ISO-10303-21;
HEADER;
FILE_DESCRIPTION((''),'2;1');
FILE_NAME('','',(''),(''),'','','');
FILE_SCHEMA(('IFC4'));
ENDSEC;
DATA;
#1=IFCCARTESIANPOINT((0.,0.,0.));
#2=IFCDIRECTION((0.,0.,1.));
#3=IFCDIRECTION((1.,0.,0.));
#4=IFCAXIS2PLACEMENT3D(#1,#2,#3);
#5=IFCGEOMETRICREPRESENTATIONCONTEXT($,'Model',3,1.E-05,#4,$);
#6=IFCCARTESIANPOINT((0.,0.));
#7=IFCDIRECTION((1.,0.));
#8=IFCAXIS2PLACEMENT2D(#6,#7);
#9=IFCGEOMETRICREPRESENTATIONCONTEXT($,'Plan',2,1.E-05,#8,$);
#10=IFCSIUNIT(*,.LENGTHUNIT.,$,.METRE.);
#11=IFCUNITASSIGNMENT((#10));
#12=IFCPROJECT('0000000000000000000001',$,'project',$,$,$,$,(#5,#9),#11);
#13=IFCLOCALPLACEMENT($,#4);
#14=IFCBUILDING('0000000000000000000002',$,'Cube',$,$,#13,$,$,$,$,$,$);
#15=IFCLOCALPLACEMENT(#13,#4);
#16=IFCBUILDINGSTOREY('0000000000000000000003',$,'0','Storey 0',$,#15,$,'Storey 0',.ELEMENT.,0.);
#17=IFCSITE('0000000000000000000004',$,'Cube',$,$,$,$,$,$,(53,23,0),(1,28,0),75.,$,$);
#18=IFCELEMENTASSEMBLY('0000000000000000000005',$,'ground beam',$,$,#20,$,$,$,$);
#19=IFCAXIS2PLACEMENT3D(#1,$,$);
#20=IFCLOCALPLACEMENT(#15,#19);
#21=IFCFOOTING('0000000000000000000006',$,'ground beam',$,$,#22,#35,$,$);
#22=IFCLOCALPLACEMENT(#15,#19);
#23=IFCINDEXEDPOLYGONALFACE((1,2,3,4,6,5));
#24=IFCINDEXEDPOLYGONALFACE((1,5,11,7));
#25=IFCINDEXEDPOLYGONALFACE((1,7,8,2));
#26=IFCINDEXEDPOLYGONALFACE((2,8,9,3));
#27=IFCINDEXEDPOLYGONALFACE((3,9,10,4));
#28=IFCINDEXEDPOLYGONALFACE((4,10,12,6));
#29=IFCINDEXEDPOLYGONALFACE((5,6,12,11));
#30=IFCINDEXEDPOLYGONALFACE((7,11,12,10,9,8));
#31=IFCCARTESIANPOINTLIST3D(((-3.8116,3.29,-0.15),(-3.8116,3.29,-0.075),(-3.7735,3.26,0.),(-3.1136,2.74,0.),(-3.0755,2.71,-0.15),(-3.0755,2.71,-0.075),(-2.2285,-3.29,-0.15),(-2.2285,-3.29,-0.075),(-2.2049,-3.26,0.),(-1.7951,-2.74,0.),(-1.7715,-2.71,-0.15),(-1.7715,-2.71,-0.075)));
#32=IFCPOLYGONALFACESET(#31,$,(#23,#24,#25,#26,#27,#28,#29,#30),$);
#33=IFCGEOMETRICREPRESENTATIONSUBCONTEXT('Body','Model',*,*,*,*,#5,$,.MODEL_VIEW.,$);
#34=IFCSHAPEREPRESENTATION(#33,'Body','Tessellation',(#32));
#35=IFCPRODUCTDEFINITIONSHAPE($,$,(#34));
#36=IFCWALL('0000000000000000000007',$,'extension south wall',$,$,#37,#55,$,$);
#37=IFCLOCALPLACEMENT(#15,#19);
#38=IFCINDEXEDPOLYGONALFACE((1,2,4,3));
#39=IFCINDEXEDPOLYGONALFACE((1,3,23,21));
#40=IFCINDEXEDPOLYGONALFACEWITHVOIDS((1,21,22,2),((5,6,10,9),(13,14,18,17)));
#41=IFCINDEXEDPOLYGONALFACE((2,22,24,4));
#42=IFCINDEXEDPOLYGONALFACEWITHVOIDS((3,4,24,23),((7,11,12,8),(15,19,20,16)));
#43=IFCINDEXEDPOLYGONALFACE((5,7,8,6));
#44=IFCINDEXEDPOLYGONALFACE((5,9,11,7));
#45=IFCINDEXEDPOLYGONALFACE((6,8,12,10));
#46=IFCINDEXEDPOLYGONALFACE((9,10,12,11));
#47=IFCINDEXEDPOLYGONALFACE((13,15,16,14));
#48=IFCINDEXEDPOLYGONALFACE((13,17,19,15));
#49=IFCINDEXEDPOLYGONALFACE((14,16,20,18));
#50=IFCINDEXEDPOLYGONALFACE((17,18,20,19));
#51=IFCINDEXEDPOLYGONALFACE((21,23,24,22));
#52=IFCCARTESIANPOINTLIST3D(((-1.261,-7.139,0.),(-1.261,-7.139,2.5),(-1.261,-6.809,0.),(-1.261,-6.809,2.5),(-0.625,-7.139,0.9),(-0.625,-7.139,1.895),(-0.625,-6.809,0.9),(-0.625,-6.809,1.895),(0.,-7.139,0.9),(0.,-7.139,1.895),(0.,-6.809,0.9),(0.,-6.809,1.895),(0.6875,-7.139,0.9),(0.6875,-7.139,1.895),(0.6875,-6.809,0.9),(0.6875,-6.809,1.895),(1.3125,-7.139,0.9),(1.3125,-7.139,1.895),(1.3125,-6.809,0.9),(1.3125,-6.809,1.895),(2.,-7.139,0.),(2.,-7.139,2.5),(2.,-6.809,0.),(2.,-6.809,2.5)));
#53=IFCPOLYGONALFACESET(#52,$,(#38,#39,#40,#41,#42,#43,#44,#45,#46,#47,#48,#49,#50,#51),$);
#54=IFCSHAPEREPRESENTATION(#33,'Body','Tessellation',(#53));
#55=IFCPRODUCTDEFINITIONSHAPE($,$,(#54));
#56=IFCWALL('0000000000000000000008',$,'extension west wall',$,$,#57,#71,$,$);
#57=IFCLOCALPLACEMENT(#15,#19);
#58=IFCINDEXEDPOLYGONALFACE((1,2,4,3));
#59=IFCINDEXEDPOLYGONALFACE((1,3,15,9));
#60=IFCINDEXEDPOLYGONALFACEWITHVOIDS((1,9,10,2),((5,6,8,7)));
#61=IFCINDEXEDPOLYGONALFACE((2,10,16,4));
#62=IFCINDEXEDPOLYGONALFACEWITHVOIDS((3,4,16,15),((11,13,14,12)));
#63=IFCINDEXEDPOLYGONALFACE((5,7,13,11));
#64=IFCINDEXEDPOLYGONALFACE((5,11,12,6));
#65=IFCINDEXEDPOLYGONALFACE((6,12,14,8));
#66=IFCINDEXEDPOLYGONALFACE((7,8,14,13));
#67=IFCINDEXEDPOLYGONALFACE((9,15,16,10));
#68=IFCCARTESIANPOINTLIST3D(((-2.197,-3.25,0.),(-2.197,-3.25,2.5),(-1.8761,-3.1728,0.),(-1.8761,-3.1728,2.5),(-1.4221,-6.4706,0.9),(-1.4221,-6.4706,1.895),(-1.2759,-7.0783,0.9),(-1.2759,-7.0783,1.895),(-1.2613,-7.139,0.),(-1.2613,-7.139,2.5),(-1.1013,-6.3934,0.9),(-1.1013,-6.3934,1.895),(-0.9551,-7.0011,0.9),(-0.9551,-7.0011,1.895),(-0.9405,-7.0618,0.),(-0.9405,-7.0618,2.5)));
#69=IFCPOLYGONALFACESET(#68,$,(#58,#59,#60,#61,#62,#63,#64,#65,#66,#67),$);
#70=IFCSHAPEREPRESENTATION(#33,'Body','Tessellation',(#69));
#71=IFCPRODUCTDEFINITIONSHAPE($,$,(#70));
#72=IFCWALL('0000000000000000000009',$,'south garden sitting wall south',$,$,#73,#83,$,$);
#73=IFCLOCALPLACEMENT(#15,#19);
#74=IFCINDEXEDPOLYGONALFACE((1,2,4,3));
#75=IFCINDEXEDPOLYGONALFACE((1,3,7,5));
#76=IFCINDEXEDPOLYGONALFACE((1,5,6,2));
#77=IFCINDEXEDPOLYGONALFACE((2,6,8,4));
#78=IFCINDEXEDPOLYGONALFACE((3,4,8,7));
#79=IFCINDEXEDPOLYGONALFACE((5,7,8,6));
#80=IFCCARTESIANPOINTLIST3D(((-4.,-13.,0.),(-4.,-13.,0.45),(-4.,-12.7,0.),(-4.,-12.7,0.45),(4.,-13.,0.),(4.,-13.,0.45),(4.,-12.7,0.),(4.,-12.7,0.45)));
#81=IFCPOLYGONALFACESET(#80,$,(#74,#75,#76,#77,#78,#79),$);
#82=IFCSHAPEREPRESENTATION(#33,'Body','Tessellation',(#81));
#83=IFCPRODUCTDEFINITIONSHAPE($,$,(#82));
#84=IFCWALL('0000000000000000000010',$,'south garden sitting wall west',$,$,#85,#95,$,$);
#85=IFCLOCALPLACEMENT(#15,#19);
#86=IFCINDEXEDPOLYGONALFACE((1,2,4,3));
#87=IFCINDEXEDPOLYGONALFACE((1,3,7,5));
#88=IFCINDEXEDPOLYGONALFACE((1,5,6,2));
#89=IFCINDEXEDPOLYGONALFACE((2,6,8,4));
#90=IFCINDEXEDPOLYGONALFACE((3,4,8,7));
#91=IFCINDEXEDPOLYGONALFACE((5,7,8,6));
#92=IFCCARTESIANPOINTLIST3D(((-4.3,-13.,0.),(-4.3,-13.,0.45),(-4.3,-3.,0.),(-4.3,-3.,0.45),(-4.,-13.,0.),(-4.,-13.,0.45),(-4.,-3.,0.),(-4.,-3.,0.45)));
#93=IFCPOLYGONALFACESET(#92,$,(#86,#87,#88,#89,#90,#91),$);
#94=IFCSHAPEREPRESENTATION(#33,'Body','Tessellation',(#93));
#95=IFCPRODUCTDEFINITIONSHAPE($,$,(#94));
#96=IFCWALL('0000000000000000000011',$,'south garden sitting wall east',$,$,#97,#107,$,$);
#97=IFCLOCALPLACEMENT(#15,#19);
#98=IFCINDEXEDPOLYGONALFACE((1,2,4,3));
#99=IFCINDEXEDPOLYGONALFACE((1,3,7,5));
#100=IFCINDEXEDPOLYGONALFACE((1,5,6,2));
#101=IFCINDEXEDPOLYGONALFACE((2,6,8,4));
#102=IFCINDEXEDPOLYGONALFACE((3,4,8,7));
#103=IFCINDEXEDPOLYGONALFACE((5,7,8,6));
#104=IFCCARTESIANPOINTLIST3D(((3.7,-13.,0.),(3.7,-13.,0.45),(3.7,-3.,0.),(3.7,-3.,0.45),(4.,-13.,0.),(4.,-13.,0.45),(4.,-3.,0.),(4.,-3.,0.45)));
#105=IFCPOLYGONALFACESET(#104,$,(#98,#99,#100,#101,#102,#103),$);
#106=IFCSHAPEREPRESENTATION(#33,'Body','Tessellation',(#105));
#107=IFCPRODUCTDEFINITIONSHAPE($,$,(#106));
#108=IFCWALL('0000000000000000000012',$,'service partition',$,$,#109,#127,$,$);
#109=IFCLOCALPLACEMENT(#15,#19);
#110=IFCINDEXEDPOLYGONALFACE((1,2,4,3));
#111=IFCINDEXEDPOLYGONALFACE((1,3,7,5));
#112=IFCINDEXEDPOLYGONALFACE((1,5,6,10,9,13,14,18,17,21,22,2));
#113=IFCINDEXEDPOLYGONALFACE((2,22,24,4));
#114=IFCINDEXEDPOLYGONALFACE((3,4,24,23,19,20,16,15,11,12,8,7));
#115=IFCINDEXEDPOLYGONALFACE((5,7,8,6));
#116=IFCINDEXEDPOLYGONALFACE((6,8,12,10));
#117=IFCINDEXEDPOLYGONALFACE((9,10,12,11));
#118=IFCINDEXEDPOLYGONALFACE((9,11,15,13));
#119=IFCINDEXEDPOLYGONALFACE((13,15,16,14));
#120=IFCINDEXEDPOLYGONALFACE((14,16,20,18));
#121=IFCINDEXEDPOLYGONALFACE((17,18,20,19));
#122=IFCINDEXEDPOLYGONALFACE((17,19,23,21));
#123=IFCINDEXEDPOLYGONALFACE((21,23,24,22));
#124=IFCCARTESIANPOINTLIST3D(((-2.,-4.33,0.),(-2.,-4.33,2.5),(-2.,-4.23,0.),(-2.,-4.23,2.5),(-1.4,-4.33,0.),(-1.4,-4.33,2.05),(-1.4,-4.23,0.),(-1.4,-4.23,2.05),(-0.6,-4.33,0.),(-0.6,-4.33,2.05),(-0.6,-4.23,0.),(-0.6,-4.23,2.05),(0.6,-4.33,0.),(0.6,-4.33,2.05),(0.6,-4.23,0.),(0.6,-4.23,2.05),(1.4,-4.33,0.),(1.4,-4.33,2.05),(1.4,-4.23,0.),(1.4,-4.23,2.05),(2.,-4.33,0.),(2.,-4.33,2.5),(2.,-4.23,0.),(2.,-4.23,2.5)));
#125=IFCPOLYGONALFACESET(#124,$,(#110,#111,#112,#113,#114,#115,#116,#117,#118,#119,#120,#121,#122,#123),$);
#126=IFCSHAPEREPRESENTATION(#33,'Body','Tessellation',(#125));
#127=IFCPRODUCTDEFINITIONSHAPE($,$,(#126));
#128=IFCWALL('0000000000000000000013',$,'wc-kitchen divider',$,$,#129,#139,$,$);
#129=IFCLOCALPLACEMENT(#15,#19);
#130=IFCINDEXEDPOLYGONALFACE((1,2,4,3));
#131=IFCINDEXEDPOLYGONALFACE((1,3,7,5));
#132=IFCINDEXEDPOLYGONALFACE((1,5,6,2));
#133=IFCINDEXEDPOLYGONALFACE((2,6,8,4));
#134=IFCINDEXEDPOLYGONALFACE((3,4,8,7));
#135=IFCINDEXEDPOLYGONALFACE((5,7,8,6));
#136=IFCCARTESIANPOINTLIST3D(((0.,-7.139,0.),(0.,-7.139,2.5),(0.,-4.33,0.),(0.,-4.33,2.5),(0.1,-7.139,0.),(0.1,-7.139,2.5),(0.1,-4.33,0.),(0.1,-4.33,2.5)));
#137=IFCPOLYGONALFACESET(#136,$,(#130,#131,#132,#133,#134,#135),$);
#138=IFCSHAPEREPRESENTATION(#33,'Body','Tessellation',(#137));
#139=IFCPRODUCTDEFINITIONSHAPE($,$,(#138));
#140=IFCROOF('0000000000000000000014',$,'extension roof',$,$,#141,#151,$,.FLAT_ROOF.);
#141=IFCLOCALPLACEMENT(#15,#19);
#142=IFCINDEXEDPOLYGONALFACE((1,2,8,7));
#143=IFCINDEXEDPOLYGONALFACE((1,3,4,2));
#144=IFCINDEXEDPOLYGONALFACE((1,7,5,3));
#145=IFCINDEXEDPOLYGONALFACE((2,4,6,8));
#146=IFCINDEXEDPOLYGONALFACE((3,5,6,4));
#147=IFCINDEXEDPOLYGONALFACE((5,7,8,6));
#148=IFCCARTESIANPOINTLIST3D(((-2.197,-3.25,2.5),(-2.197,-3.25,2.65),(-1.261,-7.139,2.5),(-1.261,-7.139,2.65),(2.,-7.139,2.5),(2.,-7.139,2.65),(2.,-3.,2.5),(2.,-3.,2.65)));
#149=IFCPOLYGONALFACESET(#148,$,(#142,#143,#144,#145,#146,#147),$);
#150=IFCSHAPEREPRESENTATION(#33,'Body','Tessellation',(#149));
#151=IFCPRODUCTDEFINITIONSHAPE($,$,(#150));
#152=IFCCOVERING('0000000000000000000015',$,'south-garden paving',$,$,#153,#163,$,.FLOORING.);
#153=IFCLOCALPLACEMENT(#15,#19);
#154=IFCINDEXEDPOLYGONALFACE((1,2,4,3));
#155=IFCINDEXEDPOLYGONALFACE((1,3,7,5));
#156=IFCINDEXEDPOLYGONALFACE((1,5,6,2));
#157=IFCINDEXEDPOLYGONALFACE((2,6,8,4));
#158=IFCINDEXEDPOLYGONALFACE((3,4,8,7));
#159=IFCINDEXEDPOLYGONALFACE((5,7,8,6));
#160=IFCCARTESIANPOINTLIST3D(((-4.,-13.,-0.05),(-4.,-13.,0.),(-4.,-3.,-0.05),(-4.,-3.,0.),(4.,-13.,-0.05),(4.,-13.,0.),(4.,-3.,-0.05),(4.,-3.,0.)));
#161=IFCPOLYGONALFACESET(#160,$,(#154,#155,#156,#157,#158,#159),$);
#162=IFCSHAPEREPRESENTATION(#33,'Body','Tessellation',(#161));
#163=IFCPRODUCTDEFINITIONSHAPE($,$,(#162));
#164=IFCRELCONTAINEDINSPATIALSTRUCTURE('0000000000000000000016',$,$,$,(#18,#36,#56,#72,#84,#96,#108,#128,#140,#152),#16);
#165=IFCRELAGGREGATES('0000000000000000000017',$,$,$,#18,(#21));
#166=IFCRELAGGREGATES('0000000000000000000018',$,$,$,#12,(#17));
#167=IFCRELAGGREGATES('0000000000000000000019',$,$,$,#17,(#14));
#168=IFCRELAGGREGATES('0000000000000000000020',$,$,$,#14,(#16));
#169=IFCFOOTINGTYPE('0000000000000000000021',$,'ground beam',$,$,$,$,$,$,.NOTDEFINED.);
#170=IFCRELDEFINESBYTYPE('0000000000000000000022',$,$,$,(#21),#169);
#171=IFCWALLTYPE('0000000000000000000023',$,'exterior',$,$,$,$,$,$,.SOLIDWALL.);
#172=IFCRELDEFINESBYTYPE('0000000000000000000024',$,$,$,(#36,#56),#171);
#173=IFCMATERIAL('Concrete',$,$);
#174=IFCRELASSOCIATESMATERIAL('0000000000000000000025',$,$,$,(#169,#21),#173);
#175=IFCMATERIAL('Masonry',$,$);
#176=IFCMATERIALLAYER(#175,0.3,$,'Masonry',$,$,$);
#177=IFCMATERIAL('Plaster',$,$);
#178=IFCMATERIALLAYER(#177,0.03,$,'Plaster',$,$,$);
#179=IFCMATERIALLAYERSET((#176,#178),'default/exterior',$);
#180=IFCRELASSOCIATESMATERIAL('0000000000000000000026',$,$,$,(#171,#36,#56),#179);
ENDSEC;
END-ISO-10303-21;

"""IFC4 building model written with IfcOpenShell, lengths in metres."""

from ifc_helpers import new_model, si_unit, frame, origin_with_axes, origin_2d_with_axis, place, context, subcontext, project, spatial, polyline, indexed_curve, outline, extrude, clip, halfspace, material, layer, layer_set, layer_usage, material_profile, profile_set, profile_usage, type_object, element, aggregate, save


model = new_model("IFC4")

# Units and contexts
model_context = context("Model", 3, precision=1e-05, world=origin_with_axes())
plan_context = context("Plan", 2, precision=1e-05, world=origin_2d_with_axis())
body_context_1 = subcontext(model_context, "Body", "Model", "MODEL_VIEW")
ifc_project = project(units=[si_unit("LENGTHUNIT", "METRE")], contexts=[model_context, plan_context])

# Site, building, storey
site = spatial("IfcSite", under=ifc_project, Name="Cube", RefLatitude=(53, 23, 0), RefLongitude=(1, 28, 0), RefElevation=75.0)
building_placement = place(None, origin_with_axes())
building = spatial("IfcBuilding", under=site, at=building_placement, Name="Cube")
storey_placement = place(building_placement, origin_with_axes())
storey = spatial("IfcBuildingStorey", under=building, at=storey_placement, Name="0", Description="Storey 0", LongName="Storey 0", CompositionType="ELEMENT", Elevation=0.0)

# Element assembly, footing
assembly_placement = place(storey_placement, origin_with_axes())
assembly = element("IfcElementAssembly", 1, at=assembly_placement, inside=storey, Name="ground beam")
ifc_material_1 = material(Name="Concrete")
ifc_material_profile = material_profile(ifc_material_1, outline(polyline([(-0.26, 0.0), (-0.29, -0.075), (-0.29, -0.15), (0.29, -0.15), (0.29, -0.075), (0.26, 0.0), (-0.26, 0.0)])))
ifc_profile_set = profile_set([ifc_material_profile])
ifc_profile_usage = profile_usage(ifc_profile_set)
footing_type = type_object("IfcFootingType", Name="ground beam", PredefinedType="NOTDEFINED", material=ifc_profile_set)
footing_placement = place(assembly_placement, frame((-1.7661, -3.9723, 0.0), z_axis=(-0.233915, 0.972257, 0.0), x_axis=(-0.972257, -0.233915, 0.0)))
footing = element("IfcFooting", 2, at=footing_placement, type_object=footing_type, material=ifc_profile_usage, Name="ground beam", context=body_context_1, shape_type="Clipping", body=[
    clip(clip(extrude(outline(polyline([(-0.26, 0.0), (-0.29, -0.075), (-0.29, -0.15), (0.29, -0.15), (0.29, -0.075), (0.26, 0.0), (-0.26, 0.0)])), origin_with_axes(), (0.0, 0.0, 1.0), 8.1712), halfspace(frame((0.0, 0.0, 1.0), z_axis=(-0.618904, 0.0, -0.785467), x_axis=(0.0, 1.0, 0.0)), False)), halfspace(frame((0.0, 0.0, 7.1712), z_axis=(-0.785467, 0.0, 0.618904), x_axis=(0.0, 1.0, 0.0)), False)),
])
aggregate(assembly, [footing])

# Wall, openings
ifc_material_2 = material(Name="Masonry")
ifc_layer_1 = layer(ifc_material_2, 0.3, Name="Masonry")
ifc_material_3 = material(Name="Plaster")
ifc_layer_2 = layer(ifc_material_3, 0.03, Name="Plaster")
ifc_layer_set = layer_set([ifc_layer_1, ifc_layer_2], Name="default/exterior")
ifc_layer_usage = layer_usage(ifc_layer_set, "AXIS2", "POSITIVE", 0.0)
wall_type = type_object("IfcWallType", Name="exterior", PredefinedType="SOLIDWALL", material=ifc_layer_set)
wall_1_placement = place(storey_placement, frame((-1.261, -7.139, 0.0), z_axis=(0.0, 0.0, 1.0), x_axis=(1.0, 0.0, 0.0)))
wall_1 = element("IfcWall", 3, at=wall_1_placement, inside=storey, type_object=wall_type, material=ifc_layer_usage, Name="extension south wall", context=body_context_1, shape_type="SweptSolid", body=[
    extrude(outline(indexed_curve([(0.0, 0.0), (0.0, 0.33), (3.261, 0.33), (3.261, 0.0), (0.0, 0.0)], self_intersect=False)), origin_with_axes(), (0.0, 0.0, 1.0), 2.5),
])
opening_1_placement = place(wall_1_placement, frame((0.636, 0.0, 0.9), z_axis=(0.0, 0.0, 1.0), x_axis=(1.0, 0.0, 0.0)))
element("IfcOpeningElement", 4, at=opening_1_placement, cuts=wall_1, PredefinedType="OPENING", context=body_context_1, shape_type="SweptSolid", body=[
    extrude(outline(indexed_curve([(0.0, 0.0), (0.0, 0.5), (0.625, 0.5), (0.625, 0.0), (0.0, 0.0)], self_intersect=False)), origin_with_axes(), (0.0, 0.0, 1.0), 0.995),
])
opening_2_placement = place(wall_1_placement, frame((1.9485, 0.0, 0.9), z_axis=(0.0, 0.0, 1.0), x_axis=(1.0, 0.0, 0.0)))
element("IfcOpeningElement", 5, at=opening_2_placement, cuts=wall_1, PredefinedType="OPENING", context=body_context_1, shape_type="SweptSolid", body=[
    extrude(outline(indexed_curve([(0.0, 0.0), (0.0, 0.5), (0.625, 0.5), (0.625, 0.0), (0.0, 0.0)], self_intersect=False)), origin_with_axes(), (0.0, 0.0, 1.0), 0.995),
])

# Wall, opening
wall_2_placement = place(storey_placement, frame((-2.197, -3.25, 0.0), z_axis=(0.0, 0.0, 1.0), x_axis=(0.233916, -0.972257, 0.0)))
wall_2 = element("IfcWall", 6, at=wall_2_placement, inside=storey, type_object=wall_type, material=ifc_layer_usage, Name="extension west wall", context=body_context_1, shape_type="SweptSolid", body=[
    extrude(outline(indexed_curve([(0.0, 0.0), (0.0, 0.33), (4.0, 0.33), (4.0, 0.0), (0.0, 0.0)], self_intersect=False)), origin_with_axes(), (0.0, 0.0, 1.0), 2.5),
])
opening_3_placement = place(wall_2_placement, frame((3.3125, 0.0, 0.9), z_axis=(0.0, 0.0, 1.0), x_axis=(1.0, 0.0, 0.0)))
element("IfcOpeningElement", 7, at=opening_3_placement, cuts=wall_2, PredefinedType="OPENING", context=body_context_1, shape_type="SweptSolid", body=[
    extrude(outline(indexed_curve([(0.0, 0.0), (0.0, 0.5), (0.625, 0.5), (0.625, 0.0), (0.0, 0.0)], self_intersect=False)), origin_with_axes(), (0.0, 0.0, 1.0), 0.995),
])

# Walls
wall_3_placement = place(storey_placement, frame((-4.0, -13.0, 0.0), z_axis=(0.0, 0.0, 1.0), x_axis=(1.0, 0.0, 0.0)))
element("IfcWall", 8, at=wall_3_placement, inside=storey, Name="south garden sitting wall south", context=body_context_1, shape_type="SweptSolid", body=[
    extrude(outline(indexed_curve([(0.0, 0.0), (0.0, 0.3), (8.0, 0.3), (8.0, 0.0), (0.0, 0.0)], self_intersect=False)), origin_with_axes(), (0.0, 0.0, 1.0), 0.45),
])
for number, where, z_axis, x_axis, name in (
    (9, (-4.0, -13.0, 0.0), (0.0, 0.0, 1.0), (0.0, 1.0, 0.0), "south garden sitting wall west"),
    (10, (4.0, -13.0, 0.0), (0.0, 0.0, 1.0), (0.0, 1.0, 0.0), "south garden sitting wall east"),
):
    element("IfcWall", number, at=place(storey_placement, frame(where, z_axis=z_axis, x_axis=x_axis)), inside=storey, Name=name, context=body_context_1, shape_type="SweptSolid", body=[
        extrude(outline(indexed_curve([(0.0, 0.0), (0.0, 0.3), (10.0, 0.3), (10.0, 0.0), (0.0, 0.0)], self_intersect=False)), origin_with_axes(), (0.0, 0.0, 1.0), 0.45),
    ])

# Wall, openings
wall_4_placement = place(storey_placement, frame((-2.0, -4.33, 0.0), z_axis=(0.0, 0.0, 1.0), x_axis=(1.0, 0.0, 0.0)))
wall_4 = element("IfcWall", 11, at=wall_4_placement, inside=storey, Name="service partition", context=body_context_1, shape_type="SweptSolid", body=[
    extrude(outline(indexed_curve([(0.0, 0.0), (0.0, 0.1), (4.0, 0.1), (4.0, 0.0), (0.0, 0.0)], self_intersect=False)), origin_with_axes(), (0.0, 0.0, 1.0), 2.5),
])
opening_4_placement = place(wall_4_placement, frame((0.6, -0.05, 0.0), z_axis=(0.0, 0.0, 1.0), x_axis=(1.0, 0.0, 0.0)))
element("IfcOpeningElement", 12, at=opening_4_placement, cuts=wall_4, context=body_context_1, shape_type="SweptSolid", body=[
    extrude(outline(indexed_curve([(0.0, 0.0), (0.0, 0.3), (0.8, 0.3), (0.8, 0.0), (0.0, 0.0)], self_intersect=False)), origin_with_axes(), (0.0, 0.0, 1.0), 2.05),
])
opening_5_placement = place(wall_4_placement, frame((2.6, -0.05, 0.0), z_axis=(0.0, 0.0, 1.0), x_axis=(1.0, 0.0, 0.0)))
element("IfcOpeningElement", 13, at=opening_5_placement, cuts=wall_4, context=body_context_1, shape_type="SweptSolid", body=[
    extrude(outline(indexed_curve([(0.0, 0.0), (0.0, 0.3), (0.8, 0.3), (0.8, 0.0), (0.0, 0.0)], self_intersect=False)), origin_with_axes(), (0.0, 0.0, 1.0), 2.05),
])

# Wall
wall_5_placement = place(storey_placement, frame((0.0, -4.33, 0.0), z_axis=(0.0, 0.0, 1.0), x_axis=(0.0, -1.0, 0.0)))
element("IfcWall", 14, at=wall_5_placement, inside=storey, Name="wc-kitchen divider", context=body_context_1, shape_type="SweptSolid", body=[
    extrude(outline(indexed_curve([(0.0, 0.0), (0.0, 0.1), (2.809, 0.1), (2.809, 0.0), (0.0, 0.0)], self_intersect=False)), origin_with_axes(), (0.0, 0.0, 1.0), 2.5),
])

# Roof
roof_placement = place(storey_placement, frame((-1.261, -7.139, 2.5), z_axis=(0.0, 0.0, 1.0), x_axis=(1.0, 0.0, 0.0)))
element("IfcRoof", 15, at=roof_placement, inside=storey, Name="extension roof", PredefinedType="FLAT_ROOF", context=body_context_1, shape_type="SweptSolid", body=[
    extrude(outline(indexed_curve([(0.0, 0.0), (3.261, 0.0), (3.261, 4.139), (-0.936, 3.889)])), None, (0.0, 0.0, 1.0), 0.15),
])

# Covering
covering_placement = place(storey_placement, frame((-4.0, -13.0, 0.0), z_axis=(0.0, 0.0, 1.0), x_axis=(1.0, 0.0, 0.0)))
element("IfcCovering", 16, at=covering_placement, inside=storey, Name="south-garden paving", PredefinedType="FLOORING", context=body_context_1, shape_type="SweptSolid", body=[
    extrude(outline(indexed_curve([(0.0, 0.0), (8.0, 0.0), (8.0, 10.0), (0.0, 10.0)])), None, (0.0, 0.0, -1.0), 0.05),
])

save(model, "model.ifc")
